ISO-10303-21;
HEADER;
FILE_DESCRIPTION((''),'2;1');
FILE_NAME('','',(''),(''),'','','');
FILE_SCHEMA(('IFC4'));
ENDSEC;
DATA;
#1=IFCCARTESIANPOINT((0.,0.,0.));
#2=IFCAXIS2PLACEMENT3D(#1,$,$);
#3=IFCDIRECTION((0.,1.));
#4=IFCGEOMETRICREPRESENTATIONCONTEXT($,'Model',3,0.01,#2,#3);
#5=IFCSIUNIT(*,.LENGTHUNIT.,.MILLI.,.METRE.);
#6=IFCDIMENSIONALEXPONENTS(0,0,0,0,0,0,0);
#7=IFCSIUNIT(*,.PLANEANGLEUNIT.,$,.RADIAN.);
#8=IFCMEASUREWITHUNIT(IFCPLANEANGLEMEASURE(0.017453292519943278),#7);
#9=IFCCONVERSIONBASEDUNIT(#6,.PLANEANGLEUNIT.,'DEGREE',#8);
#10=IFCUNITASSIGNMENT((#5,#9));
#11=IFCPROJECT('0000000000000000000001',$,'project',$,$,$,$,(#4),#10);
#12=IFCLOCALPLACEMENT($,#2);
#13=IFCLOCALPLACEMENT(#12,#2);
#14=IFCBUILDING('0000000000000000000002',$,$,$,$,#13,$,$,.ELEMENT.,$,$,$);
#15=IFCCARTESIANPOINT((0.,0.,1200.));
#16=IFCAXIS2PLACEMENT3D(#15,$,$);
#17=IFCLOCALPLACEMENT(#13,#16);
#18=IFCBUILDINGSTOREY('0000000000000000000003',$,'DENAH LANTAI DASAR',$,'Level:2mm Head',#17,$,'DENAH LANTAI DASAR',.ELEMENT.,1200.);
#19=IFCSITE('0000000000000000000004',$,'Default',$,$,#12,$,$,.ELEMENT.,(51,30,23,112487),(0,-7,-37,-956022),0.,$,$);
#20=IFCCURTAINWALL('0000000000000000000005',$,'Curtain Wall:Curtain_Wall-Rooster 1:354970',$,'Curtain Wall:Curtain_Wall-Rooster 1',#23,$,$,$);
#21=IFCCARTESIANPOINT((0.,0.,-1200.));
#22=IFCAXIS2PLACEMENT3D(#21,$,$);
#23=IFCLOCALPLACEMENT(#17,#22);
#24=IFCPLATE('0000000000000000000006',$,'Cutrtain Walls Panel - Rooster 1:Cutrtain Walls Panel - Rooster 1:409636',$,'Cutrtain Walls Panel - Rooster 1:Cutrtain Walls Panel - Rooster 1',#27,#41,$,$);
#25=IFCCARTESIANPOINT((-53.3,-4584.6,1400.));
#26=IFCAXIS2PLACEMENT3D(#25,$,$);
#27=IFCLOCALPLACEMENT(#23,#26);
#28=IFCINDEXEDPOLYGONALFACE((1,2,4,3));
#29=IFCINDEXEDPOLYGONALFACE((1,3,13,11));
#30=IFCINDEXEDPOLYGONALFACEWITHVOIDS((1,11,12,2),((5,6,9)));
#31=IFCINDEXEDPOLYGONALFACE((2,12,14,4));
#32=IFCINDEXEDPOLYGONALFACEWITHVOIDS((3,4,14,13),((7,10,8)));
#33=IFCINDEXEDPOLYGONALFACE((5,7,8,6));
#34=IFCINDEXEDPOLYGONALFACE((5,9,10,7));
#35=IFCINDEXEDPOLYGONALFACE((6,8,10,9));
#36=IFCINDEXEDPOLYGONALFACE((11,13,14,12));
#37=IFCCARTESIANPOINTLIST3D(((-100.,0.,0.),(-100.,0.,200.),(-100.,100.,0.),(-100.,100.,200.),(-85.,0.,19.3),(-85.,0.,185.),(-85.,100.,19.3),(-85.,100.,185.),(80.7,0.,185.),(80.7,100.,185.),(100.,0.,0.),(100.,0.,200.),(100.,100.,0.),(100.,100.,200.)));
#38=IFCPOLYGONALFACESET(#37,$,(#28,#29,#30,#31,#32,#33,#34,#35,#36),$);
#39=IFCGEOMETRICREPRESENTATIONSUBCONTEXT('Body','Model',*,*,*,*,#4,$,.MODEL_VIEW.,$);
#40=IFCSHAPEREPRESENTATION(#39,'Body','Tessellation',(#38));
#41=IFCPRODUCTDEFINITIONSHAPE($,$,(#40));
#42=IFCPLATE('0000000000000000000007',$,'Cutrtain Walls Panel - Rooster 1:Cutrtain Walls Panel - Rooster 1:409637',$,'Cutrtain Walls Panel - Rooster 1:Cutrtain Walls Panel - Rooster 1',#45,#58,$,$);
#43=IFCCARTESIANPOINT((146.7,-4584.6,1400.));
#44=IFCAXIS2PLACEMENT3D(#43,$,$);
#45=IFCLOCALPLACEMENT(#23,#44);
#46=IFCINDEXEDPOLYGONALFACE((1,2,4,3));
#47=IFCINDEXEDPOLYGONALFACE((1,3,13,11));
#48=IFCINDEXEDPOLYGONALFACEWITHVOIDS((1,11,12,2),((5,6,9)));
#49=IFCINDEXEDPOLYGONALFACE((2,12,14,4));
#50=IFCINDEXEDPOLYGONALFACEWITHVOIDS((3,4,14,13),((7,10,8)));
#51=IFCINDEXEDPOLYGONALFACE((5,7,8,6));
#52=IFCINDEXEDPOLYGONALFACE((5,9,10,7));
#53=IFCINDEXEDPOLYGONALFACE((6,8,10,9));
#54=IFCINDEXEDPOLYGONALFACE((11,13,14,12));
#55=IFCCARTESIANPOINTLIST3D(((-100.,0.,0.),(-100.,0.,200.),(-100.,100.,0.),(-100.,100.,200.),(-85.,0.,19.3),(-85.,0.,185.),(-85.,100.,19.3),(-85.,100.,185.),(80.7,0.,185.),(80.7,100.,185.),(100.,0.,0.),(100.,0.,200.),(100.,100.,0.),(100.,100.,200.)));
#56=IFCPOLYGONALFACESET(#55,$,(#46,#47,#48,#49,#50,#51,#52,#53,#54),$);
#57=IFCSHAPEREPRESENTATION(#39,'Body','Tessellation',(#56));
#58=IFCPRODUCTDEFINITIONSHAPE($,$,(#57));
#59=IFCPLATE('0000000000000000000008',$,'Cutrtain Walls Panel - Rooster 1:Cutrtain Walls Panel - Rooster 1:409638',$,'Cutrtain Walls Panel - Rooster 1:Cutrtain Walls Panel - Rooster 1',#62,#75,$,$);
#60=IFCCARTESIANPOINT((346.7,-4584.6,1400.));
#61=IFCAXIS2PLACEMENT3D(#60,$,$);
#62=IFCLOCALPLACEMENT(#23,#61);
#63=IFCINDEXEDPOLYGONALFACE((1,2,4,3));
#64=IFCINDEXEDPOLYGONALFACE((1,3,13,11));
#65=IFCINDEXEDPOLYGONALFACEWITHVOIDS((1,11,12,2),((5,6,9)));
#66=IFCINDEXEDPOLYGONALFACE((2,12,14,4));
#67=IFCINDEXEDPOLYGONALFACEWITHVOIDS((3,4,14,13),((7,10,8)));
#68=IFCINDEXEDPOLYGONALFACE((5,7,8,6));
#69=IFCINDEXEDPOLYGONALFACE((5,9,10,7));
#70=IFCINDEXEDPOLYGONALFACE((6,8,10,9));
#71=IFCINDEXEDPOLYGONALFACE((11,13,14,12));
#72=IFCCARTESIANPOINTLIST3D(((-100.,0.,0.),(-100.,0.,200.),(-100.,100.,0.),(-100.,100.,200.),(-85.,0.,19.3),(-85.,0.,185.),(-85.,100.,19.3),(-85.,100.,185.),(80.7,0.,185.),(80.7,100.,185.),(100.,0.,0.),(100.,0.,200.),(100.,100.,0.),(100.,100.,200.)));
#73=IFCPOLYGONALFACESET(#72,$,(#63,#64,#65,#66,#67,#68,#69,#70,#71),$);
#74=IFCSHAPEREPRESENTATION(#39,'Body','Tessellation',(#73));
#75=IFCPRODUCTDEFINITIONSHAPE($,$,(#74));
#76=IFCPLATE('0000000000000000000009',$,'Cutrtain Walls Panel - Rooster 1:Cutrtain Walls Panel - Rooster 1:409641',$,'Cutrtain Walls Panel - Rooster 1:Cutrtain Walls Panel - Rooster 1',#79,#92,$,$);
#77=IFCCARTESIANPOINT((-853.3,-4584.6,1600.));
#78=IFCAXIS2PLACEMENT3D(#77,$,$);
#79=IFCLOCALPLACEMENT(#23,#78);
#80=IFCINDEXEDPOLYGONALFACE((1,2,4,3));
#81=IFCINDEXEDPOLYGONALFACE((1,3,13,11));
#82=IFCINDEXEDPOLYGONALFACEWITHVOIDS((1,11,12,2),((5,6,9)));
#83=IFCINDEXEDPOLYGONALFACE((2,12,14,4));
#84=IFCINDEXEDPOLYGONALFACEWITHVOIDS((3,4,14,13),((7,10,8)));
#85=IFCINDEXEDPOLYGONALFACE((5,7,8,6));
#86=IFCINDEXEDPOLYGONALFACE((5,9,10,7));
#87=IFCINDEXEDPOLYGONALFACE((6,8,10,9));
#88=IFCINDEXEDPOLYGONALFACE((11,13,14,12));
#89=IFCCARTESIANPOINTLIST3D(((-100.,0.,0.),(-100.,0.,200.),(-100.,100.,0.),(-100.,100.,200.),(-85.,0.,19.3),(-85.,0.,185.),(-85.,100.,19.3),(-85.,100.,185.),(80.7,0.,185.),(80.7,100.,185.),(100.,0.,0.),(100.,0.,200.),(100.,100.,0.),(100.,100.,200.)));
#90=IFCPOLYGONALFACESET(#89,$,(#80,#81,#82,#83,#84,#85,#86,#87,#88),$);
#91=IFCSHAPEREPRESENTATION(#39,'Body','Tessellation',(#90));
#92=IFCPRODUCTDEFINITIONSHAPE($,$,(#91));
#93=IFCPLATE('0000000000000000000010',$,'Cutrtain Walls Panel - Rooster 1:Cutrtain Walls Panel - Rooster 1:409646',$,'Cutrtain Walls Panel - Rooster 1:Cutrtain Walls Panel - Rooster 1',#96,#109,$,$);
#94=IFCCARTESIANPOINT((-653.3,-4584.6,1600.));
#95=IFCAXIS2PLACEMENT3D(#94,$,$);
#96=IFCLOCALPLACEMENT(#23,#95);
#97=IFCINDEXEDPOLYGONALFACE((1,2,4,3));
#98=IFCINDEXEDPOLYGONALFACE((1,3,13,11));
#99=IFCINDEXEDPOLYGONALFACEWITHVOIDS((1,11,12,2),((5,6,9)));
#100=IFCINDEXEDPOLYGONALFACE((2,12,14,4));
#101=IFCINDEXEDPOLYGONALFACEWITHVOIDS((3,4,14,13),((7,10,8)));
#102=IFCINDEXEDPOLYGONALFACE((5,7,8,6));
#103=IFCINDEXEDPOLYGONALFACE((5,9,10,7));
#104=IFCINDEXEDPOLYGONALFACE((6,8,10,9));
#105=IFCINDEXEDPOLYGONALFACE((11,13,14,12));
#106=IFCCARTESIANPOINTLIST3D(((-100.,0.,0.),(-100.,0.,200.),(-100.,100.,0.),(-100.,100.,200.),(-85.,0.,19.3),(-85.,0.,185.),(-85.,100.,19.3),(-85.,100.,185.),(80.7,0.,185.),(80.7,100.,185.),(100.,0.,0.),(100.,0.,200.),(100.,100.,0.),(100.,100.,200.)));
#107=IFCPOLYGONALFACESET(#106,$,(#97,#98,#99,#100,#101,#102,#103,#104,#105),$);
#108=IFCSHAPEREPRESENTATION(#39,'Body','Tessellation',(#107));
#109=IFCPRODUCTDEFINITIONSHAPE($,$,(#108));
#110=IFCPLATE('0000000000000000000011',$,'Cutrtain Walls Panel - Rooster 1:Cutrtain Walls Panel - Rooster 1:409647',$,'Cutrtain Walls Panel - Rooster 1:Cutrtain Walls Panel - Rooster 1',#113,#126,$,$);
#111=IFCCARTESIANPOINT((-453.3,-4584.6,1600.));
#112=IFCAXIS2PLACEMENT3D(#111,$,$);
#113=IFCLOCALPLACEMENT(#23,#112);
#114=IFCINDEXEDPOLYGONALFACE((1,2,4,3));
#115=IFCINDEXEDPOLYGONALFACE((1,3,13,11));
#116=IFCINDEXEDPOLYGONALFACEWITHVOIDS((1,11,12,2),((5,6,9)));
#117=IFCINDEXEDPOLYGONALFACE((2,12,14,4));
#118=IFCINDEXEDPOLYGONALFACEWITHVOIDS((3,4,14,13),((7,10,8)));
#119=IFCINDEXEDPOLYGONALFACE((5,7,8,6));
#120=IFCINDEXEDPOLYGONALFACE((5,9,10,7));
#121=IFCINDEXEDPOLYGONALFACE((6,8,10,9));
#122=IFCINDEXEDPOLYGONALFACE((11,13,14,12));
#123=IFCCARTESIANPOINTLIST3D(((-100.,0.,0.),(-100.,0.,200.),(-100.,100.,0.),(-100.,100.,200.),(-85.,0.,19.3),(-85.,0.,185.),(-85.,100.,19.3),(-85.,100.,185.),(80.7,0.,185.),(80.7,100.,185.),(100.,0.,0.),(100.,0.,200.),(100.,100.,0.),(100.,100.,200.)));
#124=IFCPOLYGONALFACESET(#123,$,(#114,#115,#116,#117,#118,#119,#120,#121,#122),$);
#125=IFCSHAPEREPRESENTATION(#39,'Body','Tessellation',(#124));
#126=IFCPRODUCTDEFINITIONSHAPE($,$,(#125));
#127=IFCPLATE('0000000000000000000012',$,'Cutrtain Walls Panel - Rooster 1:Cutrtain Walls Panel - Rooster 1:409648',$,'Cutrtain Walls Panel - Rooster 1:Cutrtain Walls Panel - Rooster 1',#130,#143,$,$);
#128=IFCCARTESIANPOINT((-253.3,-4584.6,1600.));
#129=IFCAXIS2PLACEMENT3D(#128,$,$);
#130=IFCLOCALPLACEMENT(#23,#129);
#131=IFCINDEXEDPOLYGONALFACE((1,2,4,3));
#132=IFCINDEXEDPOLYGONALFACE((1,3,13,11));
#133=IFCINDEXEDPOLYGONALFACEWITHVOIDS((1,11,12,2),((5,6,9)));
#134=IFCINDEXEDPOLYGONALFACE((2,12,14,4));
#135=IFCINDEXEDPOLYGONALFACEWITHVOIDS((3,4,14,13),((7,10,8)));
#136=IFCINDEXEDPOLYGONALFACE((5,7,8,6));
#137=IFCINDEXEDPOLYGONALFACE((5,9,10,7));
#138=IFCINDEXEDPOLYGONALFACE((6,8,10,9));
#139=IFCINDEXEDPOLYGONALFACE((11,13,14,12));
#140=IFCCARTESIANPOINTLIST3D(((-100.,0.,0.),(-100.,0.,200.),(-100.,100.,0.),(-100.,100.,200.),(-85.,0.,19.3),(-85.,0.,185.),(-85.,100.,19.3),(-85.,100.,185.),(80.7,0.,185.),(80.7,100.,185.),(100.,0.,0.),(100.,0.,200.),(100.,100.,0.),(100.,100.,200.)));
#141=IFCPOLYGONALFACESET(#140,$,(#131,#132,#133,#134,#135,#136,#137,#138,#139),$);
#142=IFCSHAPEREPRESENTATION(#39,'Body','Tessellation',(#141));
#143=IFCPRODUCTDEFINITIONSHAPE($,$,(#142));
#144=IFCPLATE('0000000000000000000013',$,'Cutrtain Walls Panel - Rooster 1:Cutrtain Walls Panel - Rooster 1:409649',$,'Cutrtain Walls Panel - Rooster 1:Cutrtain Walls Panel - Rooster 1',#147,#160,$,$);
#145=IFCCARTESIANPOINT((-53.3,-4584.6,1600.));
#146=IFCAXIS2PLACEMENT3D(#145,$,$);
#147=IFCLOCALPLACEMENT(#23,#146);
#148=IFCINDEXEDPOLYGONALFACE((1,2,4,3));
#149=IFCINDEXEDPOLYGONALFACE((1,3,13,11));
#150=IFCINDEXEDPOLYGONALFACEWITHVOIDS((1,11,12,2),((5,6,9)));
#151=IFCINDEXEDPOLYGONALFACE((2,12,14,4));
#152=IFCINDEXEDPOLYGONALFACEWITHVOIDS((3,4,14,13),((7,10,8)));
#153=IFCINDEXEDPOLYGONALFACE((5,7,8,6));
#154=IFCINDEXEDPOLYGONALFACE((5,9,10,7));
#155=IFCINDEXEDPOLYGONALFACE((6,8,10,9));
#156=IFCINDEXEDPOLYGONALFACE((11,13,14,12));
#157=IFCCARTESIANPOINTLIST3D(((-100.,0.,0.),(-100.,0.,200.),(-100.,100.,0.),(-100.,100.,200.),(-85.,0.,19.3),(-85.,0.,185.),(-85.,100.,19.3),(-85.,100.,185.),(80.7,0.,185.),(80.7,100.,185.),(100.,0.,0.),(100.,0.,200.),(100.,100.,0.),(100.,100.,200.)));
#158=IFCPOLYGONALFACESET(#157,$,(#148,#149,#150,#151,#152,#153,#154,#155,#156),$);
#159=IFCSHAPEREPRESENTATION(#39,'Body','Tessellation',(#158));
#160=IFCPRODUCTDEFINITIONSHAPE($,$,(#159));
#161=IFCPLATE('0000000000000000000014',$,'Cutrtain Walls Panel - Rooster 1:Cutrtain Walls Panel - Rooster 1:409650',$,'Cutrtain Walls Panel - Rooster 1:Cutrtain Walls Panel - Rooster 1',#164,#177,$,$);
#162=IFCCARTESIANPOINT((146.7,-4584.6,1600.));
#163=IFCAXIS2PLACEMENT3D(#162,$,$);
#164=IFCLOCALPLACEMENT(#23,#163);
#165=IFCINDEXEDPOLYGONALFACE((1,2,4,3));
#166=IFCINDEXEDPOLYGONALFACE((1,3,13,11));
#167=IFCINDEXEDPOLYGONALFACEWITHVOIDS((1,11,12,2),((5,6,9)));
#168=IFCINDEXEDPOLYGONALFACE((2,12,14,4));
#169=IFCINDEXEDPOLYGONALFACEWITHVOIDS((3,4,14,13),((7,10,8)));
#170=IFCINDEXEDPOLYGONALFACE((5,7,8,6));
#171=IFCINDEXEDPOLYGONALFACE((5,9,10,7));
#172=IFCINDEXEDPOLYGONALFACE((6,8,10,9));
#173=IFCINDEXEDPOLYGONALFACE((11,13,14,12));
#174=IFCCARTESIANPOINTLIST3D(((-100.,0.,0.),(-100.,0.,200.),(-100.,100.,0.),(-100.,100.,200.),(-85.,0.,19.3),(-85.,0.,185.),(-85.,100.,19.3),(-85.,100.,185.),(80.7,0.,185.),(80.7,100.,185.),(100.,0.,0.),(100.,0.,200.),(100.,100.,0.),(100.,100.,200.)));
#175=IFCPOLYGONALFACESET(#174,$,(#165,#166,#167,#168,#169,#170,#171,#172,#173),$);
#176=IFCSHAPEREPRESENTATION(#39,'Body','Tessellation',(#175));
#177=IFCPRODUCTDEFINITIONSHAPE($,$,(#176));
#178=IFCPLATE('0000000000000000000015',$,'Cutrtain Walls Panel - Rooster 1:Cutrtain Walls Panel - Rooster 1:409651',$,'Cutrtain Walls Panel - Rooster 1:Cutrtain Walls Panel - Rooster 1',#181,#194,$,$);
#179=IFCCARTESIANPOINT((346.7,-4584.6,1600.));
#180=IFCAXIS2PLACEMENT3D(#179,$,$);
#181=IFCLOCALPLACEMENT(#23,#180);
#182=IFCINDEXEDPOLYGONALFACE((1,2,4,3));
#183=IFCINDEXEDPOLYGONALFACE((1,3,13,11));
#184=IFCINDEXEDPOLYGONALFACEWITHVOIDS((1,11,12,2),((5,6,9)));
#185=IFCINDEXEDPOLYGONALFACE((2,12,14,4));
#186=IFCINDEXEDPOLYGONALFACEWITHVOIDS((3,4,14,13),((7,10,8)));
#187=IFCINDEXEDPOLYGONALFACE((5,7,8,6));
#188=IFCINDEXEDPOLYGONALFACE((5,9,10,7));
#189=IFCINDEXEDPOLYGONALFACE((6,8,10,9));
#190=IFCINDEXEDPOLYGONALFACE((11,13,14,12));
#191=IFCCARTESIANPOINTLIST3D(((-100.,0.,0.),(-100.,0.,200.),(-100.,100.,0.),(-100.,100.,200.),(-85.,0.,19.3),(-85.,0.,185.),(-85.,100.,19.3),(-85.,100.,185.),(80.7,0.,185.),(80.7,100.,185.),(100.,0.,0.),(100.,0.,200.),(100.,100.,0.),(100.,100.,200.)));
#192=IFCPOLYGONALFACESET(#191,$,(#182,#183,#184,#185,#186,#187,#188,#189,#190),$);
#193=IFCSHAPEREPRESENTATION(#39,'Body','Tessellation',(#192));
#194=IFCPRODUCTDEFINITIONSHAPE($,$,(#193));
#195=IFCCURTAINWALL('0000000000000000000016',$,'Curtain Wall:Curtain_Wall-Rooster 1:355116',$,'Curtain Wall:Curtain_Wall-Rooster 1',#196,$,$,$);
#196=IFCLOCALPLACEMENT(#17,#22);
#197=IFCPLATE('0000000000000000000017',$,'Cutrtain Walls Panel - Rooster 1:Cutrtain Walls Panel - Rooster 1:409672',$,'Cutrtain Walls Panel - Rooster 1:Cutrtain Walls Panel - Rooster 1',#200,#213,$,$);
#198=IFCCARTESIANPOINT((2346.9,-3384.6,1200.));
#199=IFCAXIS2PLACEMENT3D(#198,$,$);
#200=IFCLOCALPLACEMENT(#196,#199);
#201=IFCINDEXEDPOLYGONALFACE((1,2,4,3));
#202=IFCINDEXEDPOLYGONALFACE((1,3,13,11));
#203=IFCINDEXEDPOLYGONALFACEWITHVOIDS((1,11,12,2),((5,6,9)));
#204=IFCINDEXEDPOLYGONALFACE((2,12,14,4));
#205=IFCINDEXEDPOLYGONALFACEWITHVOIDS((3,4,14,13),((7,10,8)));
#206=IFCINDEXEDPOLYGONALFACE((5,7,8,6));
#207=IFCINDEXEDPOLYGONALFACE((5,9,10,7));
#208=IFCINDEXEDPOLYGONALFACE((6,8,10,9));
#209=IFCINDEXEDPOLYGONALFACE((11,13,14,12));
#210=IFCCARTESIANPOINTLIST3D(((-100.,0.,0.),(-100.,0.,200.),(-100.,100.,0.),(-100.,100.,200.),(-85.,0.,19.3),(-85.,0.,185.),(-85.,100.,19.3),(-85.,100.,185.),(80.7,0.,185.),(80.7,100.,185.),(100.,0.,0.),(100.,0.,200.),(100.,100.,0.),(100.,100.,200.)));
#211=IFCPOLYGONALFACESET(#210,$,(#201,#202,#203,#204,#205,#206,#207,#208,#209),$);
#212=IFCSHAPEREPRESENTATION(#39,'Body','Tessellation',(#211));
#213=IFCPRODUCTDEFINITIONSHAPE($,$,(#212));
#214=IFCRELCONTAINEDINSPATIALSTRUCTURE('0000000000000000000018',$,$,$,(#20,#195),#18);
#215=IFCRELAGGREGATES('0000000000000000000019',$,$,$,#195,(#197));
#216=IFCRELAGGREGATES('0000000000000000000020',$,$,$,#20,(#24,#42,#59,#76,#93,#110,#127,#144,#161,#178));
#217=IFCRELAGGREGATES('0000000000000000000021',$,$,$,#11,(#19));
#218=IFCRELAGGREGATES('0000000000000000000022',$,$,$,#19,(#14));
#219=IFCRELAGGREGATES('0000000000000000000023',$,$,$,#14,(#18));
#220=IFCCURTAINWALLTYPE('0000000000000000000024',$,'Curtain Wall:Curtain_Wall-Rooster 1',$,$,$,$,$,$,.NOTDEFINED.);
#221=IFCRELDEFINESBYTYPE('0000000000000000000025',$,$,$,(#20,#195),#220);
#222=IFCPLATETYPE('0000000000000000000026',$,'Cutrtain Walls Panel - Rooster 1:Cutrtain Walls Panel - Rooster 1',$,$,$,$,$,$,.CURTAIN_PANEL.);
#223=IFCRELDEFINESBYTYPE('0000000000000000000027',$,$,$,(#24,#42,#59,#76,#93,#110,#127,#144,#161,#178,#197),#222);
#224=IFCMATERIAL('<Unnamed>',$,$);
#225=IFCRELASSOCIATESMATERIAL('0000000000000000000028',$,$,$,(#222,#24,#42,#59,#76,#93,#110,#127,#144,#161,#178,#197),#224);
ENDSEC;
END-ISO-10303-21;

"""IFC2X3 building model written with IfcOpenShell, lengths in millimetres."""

from ifc_helpers import new_model, entity, si_unit, converted_unit, direction, frame, origin, place, context, subcontext, project, spatial, polyline, outline, extrude, source, transform, mapped, material, type_object, type_shapes, element, aggregate, save


model = new_model("IFC2X3")

# Units and contexts
model_context = context("Model", 3, precision=0.01, world=origin(), true_north=direction((0.0, 1.0)))
body_context = subcontext(model_context, "Body", "Model", "MODEL_VIEW")
ifc_project = project(units=[si_unit("LENGTHUNIT", "METRE", prefix="MILLI"), converted_unit("PLANEANGLEUNIT", "DEGREE", entity("IfcPlaneAngleMeasure", 0.017453292519943278), si_unit("PLANEANGLEUNIT", "RADIAN"), dimensions=[0, 0, 0, 0, 0, 0, 0])], contexts=[model_context])

# Site, building, storey
site_placement = place(None, origin())
site = spatial("IfcSite", under=ifc_project, at=site_placement, Name="Default", CompositionType="ELEMENT", RefLatitude=(51, 30, 23, 112487), RefLongitude=(0, -7, -37, -956022), RefElevation=0.0)
building_placement = place(site_placement, origin())
building = spatial("IfcBuilding", under=site, at=building_placement, CompositionType="ELEMENT")
storey_placement = place(building_placement, frame((0.0, 0.0, 1200.0)))
storey = spatial("IfcBuildingStorey", under=building, at=storey_placement, Name="DENAH LANTAI DASAR", ObjectType="Level:2mm Head", LongName="DENAH LANTAI DASAR", CompositionType="ELEMENT", Elevation=1200.0)

# Curtain wall, plates
curtain_wall_type = type_object("IfcCurtainWallType", Name="Curtain Wall:Curtain_Wall-Rooster 1", PredefinedType="NOTDEFINED")
curtain_wall_1_placement = place(storey_placement, frame((0.0, 0.0, -1200.0)))
curtain_wall_1 = element("IfcCurtainWall", 1, at=curtain_wall_1_placement, inside=storey, type_object=curtain_wall_type, Name="Curtain Wall:Curtain_Wall-Rooster 1:354970", ObjectType="Curtain Wall:Curtain_Wall-Rooster 1")
ifc_material_1 = material(Name="<Unnamed>")
plate_type_1 = type_object("IfcPlateType", Name="Cutrtain Walls Panel - Rooster 1:Cutrtain Walls Panel - Rooster 1", PredefinedType="CURTAIN_PANEL", material=ifc_material_1)
shared_shape_1 = source(origin(), body_context, "Body", "SweptSolid", [
    extrude(outline(polyline([(-100.0, -100.0), (100.0, -100.0), (100.0, 100.0), (-100.0, 100.0), (-100.0, -100.0)]), holes=[polyline([(80.7, 85.0), (-85.0, -80.7), (-85.0, 85.0), (80.7, 85.0)])]), frame((0.0, 0.0, 100.0), z_axis=(0.0, 1.0, 0.0), x_axis=(0.0, 0.0, -1.0)), (0.0, 0.0, 1.0), 100.0),
])
type_shapes(plate_type_1, [shared_shape_1])
plate_1_placement = place(curtain_wall_1_placement, frame((-53.3, -4584.6, 1400.0)))
plate_1 = element("IfcPlate", 2, at=plate_1_placement, type_object=plate_type_1, material=ifc_material_1, Name="Cutrtain Walls Panel - Rooster 1:Cutrtain Walls Panel - Rooster 1:409636", ObjectType="Cutrtain Walls Panel - Rooster 1:Cutrtain Walls Panel - Rooster 1", context=body_context, shape_type="MappedRepresentation", body=[
    mapped(shared_shape_1, transform((0.0, 0.0, 0.0), scale=1.0)),
])
plate_2_placement = place(curtain_wall_1_placement, frame((146.7, -4584.6, 1400.0)))
plate_2 = element("IfcPlate", 3, at=plate_2_placement, type_object=plate_type_1, material=ifc_material_1, Name="Cutrtain Walls Panel - Rooster 1:Cutrtain Walls Panel - Rooster 1:409637", ObjectType="Cutrtain Walls Panel - Rooster 1:Cutrtain Walls Panel - Rooster 1", context=body_context, shape_type="MappedRepresentation", body=[
    mapped(shared_shape_1, transform((0.0, 0.0, 0.0), scale=1.0)),
])
plate_3_placement = place(curtain_wall_1_placement, frame((346.7, -4584.6, 1400.0)))
plate_3 = element("IfcPlate", 4, at=plate_3_placement, type_object=plate_type_1, material=ifc_material_1, Name="Cutrtain Walls Panel - Rooster 1:Cutrtain Walls Panel - Rooster 1:409638", ObjectType="Cutrtain Walls Panel - Rooster 1:Cutrtain Walls Panel - Rooster 1", context=body_context, shape_type="MappedRepresentation", body=[
    mapped(shared_shape_1, transform((0.0, 0.0, 0.0), scale=1.0)),
])
plate_4_placement = place(curtain_wall_1_placement, frame((-853.3, -4584.6, 1600.0)))
plate_4 = element("IfcPlate", 5, at=plate_4_placement, type_object=plate_type_1, material=ifc_material_1, Name="Cutrtain Walls Panel - Rooster 1:Cutrtain Walls Panel - Rooster 1:409641", ObjectType="Cutrtain Walls Panel - Rooster 1:Cutrtain Walls Panel - Rooster 1", context=body_context, shape_type="MappedRepresentation", body=[
    mapped(shared_shape_1, transform((0.0, 0.0, 0.0), scale=1.0)),
])
plate_5_placement = place(curtain_wall_1_placement, frame((-653.3, -4584.6, 1600.0)))
plate_5 = element("IfcPlate", 6, at=plate_5_placement, type_object=plate_type_1, material=ifc_material_1, Name="Cutrtain Walls Panel - Rooster 1:Cutrtain Walls Panel - Rooster 1:409646", ObjectType="Cutrtain Walls Panel - Rooster 1:Cutrtain Walls Panel - Rooster 1", context=body_context, shape_type="MappedRepresentation", body=[
    mapped(shared_shape_1, transform((0.0, 0.0, 0.0), scale=1.0)),
])
plate_6_placement = place(curtain_wall_1_placement, frame((-453.3, -4584.6, 1600.0)))
plate_6 = element("IfcPlate", 7, at=plate_6_placement, type_object=plate_type_1, material=ifc_material_1, Name="Cutrtain Walls Panel - Rooster 1:Cutrtain Walls Panel - Rooster 1:409647", ObjectType="Cutrtain Walls Panel - Rooster 1:Cutrtain Walls Panel - Rooster 1", context=body_context, shape_type="MappedRepresentation", body=[
    mapped(shared_shape_1, transform((0.0, 0.0, 0.0), scale=1.0)),
])
plate_7_placement = place(curtain_wall_1_placement, frame((-253.3, -4584.6, 1600.0)))
plate_7 = element("IfcPlate", 8, at=plate_7_placement, type_object=plate_type_1, material=ifc_material_1, Name="Cutrtain Walls Panel - Rooster 1:Cutrtain Walls Panel - Rooster 1:409648", ObjectType="Cutrtain Walls Panel - Rooster 1:Cutrtain Walls Panel - Rooster 1", context=body_context, shape_type="MappedRepresentation", body=[
    mapped(shared_shape_1, transform((0.0, 0.0, 0.0), scale=1.0)),
])
plate_8_placement = place(curtain_wall_1_placement, frame((-53.3, -4584.6, 1600.0)))
plate_8 = element("IfcPlate", 9, at=plate_8_placement, type_object=plate_type_1, material=ifc_material_1, Name="Cutrtain Walls Panel - Rooster 1:Cutrtain Walls Panel - Rooster 1:409649", ObjectType="Cutrtain Walls Panel - Rooster 1:Cutrtain Walls Panel - Rooster 1", context=body_context, shape_type="MappedRepresentation", body=[
    mapped(shared_shape_1, transform((0.0, 0.0, 0.0), scale=1.0)),
])
plate_9_placement = place(curtain_wall_1_placement, frame((146.7, -4584.6, 1600.0)))
plate_9 = element("IfcPlate", 10, at=plate_9_placement, type_object=plate_type_1, material=ifc_material_1, Name="Cutrtain Walls Panel - Rooster 1:Cutrtain Walls Panel - Rooster 1:409650", ObjectType="Cutrtain Walls Panel - Rooster 1:Cutrtain Walls Panel - Rooster 1", context=body_context, shape_type="MappedRepresentation", body=[
    mapped(shared_shape_1, transform((0.0, 0.0, 0.0), scale=1.0)),
])
plate_10_placement = place(curtain_wall_1_placement, frame((346.7, -4584.6, 1600.0)))
plate_10 = element("IfcPlate", 11, at=plate_10_placement, type_object=plate_type_1, material=ifc_material_1, Name="Cutrtain Walls Panel - Rooster 1:Cutrtain Walls Panel - Rooster 1:409651", ObjectType="Cutrtain Walls Panel - Rooster 1:Cutrtain Walls Panel - Rooster 1", context=body_context, shape_type="MappedRepresentation", body=[
    mapped(shared_shape_1, transform((0.0, 0.0, 0.0), scale=1.0)),
])

# Curtain wall, plate
curtain_wall_2_placement = place(storey_placement, frame((0.0, 0.0, -1200.0)))
curtain_wall_2 = element("IfcCurtainWall", 12, at=curtain_wall_2_placement, inside=storey, type_object=curtain_wall_type, Name="Curtain Wall:Curtain_Wall-Rooster 1:355116", ObjectType="Curtain Wall:Curtain_Wall-Rooster 1")
plate_11_placement = place(curtain_wall_2_placement, frame((2346.9, -3384.6, 1200.0)))
plate_11 = element("IfcPlate", 13, at=plate_11_placement, type_object=plate_type_1, material=ifc_material_1, Name="Cutrtain Walls Panel - Rooster 1:Cutrtain Walls Panel - Rooster 1:409672", ObjectType="Cutrtain Walls Panel - Rooster 1:Cutrtain Walls Panel - Rooster 1", context=body_context, shape_type="MappedRepresentation", body=[
    mapped(shared_shape_1, transform((0.0, 0.0, 0.0), scale=1.0)),
])
aggregate(curtain_wall_2, [plate_11])

aggregate(curtain_wall_1, [plate_1, plate_2, plate_3, plate_4, plate_5, plate_6, plate_7, plate_8, plate_9, plate_10])

save(model, "model.ifc")
